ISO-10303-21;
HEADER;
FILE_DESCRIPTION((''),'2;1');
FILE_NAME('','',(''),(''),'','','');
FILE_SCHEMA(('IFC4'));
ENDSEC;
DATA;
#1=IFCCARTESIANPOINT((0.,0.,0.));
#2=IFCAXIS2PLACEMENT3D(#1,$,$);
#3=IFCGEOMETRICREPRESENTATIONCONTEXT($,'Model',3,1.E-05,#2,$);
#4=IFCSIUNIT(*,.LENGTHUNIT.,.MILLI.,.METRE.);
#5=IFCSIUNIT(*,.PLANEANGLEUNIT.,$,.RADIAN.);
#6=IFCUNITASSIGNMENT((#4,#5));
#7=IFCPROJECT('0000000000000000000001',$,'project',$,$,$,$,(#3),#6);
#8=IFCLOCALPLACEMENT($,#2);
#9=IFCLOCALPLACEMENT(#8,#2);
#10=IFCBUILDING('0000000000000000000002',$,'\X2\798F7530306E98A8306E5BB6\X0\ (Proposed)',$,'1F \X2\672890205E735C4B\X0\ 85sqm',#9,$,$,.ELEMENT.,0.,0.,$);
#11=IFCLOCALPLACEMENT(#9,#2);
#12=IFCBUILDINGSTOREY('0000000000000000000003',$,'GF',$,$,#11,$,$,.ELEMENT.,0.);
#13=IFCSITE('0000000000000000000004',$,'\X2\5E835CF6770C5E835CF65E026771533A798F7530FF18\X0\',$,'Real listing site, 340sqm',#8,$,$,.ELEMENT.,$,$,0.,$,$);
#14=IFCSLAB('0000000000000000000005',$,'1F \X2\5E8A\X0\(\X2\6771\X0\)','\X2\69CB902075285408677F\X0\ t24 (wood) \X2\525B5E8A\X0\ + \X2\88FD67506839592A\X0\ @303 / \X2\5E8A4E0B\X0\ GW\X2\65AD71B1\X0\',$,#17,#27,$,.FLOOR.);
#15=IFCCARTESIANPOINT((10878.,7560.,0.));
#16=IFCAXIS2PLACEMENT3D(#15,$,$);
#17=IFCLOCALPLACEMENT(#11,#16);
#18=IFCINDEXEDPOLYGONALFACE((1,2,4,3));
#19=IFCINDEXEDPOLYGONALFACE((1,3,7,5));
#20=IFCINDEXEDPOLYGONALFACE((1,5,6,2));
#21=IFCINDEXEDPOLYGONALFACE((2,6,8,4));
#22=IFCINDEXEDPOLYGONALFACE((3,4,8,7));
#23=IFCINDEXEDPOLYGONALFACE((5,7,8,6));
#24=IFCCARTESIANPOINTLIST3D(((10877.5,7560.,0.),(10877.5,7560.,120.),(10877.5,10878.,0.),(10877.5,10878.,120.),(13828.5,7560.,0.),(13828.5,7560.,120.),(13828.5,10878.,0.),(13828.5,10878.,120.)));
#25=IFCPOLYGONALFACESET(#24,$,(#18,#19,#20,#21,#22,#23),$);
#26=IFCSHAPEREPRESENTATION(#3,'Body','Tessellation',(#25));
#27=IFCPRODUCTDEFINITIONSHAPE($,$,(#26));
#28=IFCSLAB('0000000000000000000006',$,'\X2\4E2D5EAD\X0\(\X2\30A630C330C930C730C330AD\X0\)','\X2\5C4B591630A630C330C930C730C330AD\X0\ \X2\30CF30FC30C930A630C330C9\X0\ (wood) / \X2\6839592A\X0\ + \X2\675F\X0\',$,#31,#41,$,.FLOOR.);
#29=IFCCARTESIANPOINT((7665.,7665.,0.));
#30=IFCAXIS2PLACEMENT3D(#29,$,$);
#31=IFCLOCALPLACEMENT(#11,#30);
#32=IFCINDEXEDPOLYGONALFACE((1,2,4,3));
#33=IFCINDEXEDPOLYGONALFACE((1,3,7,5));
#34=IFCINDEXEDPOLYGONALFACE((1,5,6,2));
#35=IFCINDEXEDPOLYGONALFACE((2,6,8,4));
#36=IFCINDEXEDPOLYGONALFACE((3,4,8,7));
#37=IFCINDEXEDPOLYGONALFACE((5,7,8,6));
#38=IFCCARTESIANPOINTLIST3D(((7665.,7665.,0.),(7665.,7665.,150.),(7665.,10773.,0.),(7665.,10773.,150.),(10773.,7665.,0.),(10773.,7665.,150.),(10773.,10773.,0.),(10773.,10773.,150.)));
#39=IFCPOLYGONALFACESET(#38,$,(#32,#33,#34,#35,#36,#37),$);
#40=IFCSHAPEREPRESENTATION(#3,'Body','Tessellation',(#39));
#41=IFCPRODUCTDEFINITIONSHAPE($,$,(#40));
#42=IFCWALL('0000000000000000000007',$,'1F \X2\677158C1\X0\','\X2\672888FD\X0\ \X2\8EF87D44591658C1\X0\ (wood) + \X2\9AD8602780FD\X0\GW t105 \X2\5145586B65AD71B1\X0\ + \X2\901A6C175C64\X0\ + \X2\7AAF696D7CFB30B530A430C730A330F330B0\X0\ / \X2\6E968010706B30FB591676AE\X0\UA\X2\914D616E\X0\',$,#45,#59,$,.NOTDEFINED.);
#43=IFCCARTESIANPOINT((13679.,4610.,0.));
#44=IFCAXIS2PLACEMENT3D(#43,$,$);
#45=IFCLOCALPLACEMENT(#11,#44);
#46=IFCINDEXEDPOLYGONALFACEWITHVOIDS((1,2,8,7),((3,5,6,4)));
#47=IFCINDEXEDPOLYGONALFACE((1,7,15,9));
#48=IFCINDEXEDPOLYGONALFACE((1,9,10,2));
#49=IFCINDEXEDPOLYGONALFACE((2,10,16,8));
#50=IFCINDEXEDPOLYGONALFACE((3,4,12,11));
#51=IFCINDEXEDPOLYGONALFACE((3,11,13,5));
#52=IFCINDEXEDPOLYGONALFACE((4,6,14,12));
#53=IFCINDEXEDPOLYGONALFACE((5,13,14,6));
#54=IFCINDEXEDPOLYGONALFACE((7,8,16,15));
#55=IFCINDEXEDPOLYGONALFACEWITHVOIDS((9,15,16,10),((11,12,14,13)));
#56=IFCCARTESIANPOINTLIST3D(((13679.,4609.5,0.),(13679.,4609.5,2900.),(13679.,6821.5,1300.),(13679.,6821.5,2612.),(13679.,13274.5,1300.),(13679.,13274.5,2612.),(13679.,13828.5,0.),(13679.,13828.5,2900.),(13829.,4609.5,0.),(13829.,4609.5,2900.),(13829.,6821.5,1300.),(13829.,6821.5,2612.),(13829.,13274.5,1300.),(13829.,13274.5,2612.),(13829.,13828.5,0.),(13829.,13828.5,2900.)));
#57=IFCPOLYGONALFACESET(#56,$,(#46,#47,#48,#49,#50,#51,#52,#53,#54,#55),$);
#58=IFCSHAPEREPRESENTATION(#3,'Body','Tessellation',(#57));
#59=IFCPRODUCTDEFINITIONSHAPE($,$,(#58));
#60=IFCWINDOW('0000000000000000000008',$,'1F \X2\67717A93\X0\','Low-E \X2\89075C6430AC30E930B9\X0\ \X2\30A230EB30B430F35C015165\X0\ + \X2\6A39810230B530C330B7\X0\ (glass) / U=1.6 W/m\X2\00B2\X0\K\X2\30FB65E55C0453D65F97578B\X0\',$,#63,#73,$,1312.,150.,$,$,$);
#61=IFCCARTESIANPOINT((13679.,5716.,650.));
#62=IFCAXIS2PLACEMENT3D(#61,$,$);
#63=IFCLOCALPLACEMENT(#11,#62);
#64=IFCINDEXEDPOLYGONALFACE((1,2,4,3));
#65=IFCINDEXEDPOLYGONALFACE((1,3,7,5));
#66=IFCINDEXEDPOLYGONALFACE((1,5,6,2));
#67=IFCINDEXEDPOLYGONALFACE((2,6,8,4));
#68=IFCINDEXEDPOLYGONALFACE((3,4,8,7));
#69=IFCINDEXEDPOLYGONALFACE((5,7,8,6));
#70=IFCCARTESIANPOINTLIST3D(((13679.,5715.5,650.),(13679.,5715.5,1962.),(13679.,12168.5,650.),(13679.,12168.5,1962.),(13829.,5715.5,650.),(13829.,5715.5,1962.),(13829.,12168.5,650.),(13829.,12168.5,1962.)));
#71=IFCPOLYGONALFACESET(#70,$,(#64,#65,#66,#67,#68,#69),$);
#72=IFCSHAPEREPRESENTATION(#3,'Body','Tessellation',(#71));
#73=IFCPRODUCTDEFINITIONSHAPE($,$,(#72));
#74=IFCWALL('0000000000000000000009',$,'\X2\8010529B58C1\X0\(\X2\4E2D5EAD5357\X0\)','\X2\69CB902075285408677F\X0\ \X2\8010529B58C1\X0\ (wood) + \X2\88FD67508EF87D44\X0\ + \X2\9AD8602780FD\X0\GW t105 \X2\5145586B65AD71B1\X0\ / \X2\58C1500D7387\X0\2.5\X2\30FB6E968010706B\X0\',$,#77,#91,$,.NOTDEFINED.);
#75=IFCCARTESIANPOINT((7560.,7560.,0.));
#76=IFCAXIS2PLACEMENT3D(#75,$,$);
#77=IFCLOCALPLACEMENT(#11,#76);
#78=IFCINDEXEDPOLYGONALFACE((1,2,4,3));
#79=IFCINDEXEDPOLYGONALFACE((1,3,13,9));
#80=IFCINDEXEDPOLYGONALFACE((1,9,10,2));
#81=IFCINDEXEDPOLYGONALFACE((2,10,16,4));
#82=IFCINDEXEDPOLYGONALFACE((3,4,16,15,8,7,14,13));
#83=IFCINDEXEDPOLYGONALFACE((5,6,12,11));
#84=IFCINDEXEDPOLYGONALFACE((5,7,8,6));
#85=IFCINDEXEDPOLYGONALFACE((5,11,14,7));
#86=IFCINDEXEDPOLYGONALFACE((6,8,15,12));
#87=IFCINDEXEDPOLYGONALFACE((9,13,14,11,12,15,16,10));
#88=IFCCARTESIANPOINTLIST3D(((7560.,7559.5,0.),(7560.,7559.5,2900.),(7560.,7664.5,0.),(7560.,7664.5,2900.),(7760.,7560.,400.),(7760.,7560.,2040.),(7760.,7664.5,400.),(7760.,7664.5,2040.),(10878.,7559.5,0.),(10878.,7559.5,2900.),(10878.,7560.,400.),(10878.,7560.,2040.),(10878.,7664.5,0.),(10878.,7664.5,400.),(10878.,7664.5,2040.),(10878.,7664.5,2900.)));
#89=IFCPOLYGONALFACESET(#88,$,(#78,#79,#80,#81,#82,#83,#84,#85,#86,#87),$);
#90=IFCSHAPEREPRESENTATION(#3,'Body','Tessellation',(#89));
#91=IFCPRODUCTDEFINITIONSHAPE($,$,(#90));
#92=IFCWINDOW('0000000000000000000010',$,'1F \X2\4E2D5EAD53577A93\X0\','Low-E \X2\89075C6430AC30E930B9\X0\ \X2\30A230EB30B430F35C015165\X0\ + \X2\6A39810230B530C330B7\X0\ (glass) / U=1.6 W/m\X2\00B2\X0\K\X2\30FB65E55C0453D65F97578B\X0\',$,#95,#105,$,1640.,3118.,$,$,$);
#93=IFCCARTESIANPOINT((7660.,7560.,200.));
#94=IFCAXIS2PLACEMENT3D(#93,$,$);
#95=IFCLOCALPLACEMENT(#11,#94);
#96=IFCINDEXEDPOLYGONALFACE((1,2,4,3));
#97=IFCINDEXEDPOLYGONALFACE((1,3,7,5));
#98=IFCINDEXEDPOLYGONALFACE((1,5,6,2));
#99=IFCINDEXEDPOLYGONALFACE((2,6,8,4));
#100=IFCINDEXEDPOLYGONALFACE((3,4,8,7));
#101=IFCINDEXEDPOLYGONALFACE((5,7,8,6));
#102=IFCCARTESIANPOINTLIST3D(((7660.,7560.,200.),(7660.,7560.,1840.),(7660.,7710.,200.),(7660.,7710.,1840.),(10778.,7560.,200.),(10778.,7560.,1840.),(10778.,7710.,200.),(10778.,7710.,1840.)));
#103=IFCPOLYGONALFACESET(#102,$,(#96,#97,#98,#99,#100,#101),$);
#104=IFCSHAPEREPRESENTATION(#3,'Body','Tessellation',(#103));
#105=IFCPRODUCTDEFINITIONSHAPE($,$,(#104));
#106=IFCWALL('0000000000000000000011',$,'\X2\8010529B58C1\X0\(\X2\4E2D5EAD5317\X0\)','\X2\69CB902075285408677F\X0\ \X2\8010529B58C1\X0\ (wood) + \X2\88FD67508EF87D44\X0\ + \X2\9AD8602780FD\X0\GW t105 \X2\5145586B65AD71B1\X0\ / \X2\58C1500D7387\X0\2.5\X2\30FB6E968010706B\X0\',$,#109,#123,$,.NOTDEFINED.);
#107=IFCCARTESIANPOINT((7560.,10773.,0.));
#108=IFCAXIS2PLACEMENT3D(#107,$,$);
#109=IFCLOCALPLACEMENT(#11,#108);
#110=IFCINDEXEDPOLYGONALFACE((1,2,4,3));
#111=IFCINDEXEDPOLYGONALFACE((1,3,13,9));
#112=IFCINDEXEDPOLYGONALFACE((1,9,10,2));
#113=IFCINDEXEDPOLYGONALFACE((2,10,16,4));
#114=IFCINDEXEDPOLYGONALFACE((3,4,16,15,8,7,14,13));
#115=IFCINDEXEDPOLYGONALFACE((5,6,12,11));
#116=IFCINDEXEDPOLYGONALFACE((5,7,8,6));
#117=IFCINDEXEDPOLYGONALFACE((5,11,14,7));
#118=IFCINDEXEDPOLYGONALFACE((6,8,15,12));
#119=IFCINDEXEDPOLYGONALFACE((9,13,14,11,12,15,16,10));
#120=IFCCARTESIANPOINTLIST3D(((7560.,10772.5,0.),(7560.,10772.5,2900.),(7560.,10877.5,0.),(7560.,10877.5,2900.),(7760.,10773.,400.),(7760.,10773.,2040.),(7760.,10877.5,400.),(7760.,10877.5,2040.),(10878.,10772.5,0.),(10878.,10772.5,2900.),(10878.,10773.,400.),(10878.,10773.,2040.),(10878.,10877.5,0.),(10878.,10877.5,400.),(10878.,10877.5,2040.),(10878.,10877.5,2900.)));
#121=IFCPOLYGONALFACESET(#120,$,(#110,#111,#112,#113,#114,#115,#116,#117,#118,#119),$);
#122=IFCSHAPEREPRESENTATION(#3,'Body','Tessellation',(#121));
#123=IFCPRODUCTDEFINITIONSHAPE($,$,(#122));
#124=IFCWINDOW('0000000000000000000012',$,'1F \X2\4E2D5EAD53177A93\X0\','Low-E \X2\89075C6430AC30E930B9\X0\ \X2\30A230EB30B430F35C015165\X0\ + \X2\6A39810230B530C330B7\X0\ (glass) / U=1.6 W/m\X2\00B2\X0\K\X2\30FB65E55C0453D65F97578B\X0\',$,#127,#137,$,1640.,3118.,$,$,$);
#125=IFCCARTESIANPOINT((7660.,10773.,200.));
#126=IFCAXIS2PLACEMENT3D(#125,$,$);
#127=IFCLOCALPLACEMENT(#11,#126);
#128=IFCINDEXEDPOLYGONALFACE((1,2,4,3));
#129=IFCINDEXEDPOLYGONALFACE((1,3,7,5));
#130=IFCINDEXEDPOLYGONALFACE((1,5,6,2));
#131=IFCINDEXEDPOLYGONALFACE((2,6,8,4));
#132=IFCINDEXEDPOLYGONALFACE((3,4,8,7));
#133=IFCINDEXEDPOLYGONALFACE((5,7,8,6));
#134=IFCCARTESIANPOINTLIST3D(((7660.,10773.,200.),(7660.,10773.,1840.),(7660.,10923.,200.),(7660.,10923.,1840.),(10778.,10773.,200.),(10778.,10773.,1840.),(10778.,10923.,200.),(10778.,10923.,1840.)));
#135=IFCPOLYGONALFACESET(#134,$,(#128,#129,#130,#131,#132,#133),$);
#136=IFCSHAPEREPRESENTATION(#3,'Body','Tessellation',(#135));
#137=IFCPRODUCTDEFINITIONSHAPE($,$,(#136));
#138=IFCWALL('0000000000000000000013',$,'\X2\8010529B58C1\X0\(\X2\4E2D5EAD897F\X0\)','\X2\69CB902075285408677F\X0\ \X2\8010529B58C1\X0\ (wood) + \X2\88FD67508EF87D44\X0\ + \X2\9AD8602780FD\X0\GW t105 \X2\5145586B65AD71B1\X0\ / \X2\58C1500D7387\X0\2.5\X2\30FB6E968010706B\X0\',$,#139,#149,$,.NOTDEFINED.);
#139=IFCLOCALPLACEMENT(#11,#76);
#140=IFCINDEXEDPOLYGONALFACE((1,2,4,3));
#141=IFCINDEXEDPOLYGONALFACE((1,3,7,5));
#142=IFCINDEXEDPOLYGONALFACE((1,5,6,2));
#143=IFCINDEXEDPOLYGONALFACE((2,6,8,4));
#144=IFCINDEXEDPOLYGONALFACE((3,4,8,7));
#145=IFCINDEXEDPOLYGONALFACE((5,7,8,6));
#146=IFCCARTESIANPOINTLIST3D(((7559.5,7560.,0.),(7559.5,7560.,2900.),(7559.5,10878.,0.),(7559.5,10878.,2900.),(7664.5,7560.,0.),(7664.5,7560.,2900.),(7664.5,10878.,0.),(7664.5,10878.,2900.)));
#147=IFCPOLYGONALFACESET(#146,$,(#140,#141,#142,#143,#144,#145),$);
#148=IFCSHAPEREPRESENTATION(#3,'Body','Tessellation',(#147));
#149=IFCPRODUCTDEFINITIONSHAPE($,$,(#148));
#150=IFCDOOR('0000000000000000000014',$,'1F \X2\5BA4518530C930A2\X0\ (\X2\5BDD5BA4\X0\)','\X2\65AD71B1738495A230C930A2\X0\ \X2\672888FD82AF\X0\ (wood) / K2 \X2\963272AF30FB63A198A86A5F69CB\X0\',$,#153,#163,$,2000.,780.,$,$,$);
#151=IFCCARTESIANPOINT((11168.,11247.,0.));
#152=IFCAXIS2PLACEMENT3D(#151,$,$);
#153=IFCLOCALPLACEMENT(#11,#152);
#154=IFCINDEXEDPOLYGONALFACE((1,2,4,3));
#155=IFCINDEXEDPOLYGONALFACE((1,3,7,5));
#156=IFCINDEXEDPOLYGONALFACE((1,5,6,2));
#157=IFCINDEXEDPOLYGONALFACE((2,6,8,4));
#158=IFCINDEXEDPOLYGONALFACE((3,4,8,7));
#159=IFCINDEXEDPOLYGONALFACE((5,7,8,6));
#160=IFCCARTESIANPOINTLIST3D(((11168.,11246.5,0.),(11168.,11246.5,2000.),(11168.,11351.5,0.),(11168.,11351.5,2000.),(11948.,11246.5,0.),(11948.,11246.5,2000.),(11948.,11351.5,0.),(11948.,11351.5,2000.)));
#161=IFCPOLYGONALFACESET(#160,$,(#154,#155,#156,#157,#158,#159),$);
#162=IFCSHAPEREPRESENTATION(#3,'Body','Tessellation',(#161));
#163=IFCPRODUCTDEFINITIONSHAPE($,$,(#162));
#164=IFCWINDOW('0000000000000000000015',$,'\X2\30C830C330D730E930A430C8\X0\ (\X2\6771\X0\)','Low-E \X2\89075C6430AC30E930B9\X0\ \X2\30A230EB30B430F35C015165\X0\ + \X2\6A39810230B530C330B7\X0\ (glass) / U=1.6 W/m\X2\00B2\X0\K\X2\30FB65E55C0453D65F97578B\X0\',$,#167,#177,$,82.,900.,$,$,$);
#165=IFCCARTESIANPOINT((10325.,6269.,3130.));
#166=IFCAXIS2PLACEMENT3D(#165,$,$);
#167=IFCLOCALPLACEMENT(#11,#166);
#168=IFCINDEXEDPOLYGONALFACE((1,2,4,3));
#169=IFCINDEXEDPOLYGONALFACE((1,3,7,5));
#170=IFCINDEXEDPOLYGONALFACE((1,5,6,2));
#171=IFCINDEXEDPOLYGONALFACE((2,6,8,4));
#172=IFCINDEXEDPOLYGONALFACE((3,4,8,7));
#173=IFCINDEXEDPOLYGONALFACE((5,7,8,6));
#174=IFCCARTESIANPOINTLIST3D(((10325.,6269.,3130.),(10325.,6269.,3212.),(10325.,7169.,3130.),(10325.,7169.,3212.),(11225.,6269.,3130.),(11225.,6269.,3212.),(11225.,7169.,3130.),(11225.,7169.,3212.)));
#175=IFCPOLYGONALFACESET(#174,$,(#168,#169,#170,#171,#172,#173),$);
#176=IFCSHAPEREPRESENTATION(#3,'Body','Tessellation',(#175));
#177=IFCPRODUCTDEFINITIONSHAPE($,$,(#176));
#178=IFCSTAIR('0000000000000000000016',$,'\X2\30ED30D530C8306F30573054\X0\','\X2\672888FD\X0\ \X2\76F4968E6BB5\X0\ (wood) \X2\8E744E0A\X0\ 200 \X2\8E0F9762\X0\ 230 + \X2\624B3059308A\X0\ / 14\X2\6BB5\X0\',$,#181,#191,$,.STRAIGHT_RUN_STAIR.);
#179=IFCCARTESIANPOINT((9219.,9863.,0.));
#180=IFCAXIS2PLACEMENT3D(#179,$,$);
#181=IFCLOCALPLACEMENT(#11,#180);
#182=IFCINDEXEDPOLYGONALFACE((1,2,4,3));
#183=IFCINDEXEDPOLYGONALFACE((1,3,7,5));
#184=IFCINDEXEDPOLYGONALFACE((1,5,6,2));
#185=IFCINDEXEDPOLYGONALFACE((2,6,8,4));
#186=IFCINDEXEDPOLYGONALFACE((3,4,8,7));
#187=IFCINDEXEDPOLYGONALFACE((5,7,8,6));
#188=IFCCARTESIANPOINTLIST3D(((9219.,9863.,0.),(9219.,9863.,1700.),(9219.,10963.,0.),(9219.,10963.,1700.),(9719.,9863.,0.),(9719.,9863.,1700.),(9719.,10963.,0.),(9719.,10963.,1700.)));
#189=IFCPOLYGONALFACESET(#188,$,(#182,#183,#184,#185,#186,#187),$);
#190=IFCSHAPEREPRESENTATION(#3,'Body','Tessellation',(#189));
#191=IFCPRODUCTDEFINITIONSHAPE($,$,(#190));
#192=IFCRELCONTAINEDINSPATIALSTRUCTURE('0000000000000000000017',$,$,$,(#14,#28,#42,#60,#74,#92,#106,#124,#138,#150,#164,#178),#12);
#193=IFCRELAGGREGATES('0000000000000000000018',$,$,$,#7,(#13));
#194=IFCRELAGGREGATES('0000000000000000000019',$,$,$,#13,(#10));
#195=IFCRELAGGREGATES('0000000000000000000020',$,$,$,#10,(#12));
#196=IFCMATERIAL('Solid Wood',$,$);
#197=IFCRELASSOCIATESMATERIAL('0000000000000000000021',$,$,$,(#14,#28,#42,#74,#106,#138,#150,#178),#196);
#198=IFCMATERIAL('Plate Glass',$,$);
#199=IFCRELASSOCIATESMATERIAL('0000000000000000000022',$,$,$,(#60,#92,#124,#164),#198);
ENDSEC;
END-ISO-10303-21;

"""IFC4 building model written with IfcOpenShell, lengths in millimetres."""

from ifc_helpers import new_model, si_unit, frame, frame_2d, origin, place, context, project, spatial, rectangle, extrude, material, element, fill, save


model = new_model("IFC4")

# Units and contexts
model_context = context("Model", 3, precision=1e-05, world=origin())
ifc_project = project(units=[si_unit("LENGTHUNIT", "METRE", prefix="MILLI"), si_unit("PLANEANGLEUNIT", "RADIAN")], contexts=[model_context])

# Site, building, storey
site_placement = place(None, origin())
site = spatial("IfcSite", under=ifc_project, at=site_placement, Name="広島県広島市東区福田８", ObjectType="Real listing site, 340sqm", CompositionType="ELEMENT", RefElevation=0.0)
building_placement = place(site_placement, origin())
building = spatial("IfcBuilding", under=site, at=building_placement, Name="福田の風の家 (Proposed)", ObjectType="1F 木造平屋 85sqm", CompositionType="ELEMENT", ElevationOfRefHeight=0.0, ElevationOfTerrain=0.0)
storey_placement = place(building_placement, origin())
storey = spatial("IfcBuildingStorey", under=building, at=storey_placement, Name="GF", CompositionType="ELEMENT", Elevation=0.0)

# Slabs
ifc_material_1 = material(Name="Solid Wood")
slab_1_placement = place(storey_placement, frame((10878.0, 7560.0, 0.0)))
element("IfcSlab", 1, at=slab_1_placement, inside=storey, material=ifc_material_1, Name="1F 床(東)", Description="構造用合板 t24 (wood) 剛床 + 製材根太 @303 / 床下 GW断熱", PredefinedType="FLOOR", context=model_context, shape_type="SweptSolid", body=[
    extrude(rectangle(XDim=2951.0, YDim=3318.0, at=frame_2d((1475.0, 1659.0))), frame((10878.0, 7560.0, 0.0)), (0.0, 0.0, 1.0), 120.0),
])
slab_2_placement = place(storey_placement, frame((7665.0, 7665.0, 0.0)))
element("IfcSlab", 2, at=slab_2_placement, inside=storey, material=ifc_material_1, Name="中庭(ウッドデッキ)", Description="屋外ウッドデッキ ハードウッド (wood) / 根太 + 束", PredefinedType="FLOOR", context=model_context, shape_type="SweptSolid", body=[
    extrude(rectangle(XDim=3108.0, YDim=3108.0, at=frame_2d((1554.0, 1554.0))), frame((7665.0, 7665.0, 0.0)), (0.0, 0.0, 1.0), 150.0),
])

# Walls, openings, windows
wall_1_placement = place(storey_placement, frame((13679.0, 4610.0, 0.0)))
wall_1 = element("IfcWall", 3, at=wall_1_placement, inside=storey, material=ifc_material_1, Name="1F 東壁", Description="木製 軸組外壁 (wood) + 高性能GW t105 充填断熱 + 通気層 + 窯業系サイディング / 準耐火・外皮UA配慮", PredefinedType="NOTDEFINED", context=model_context, shape_type="SweptSolid", body=[
    extrude(rectangle(XDim=150.0, YDim=9219.0, at=frame_2d((75.0, 4609.0))), frame((13679.0, 4610.0, 0.0)), (0.0, 0.0, 1.0), 2900.0),
])
opening_1_placement = place(storey_placement, frame((13679.0, 5716.0, 650.0)))
opening_1 = element("IfcOpeningElement", 4, at=opening_1_placement, cuts=wall_1, PredefinedType="NOTDEFINED", context=model_context, shape_type="SweptSolid", body=[
    extrude(rectangle(XDim=150.0, YDim=6453.0, at=frame_2d((75.0, 3226.0))), frame((13679.0, 5716.0, 650.0)), (0.0, 0.0, 1.0), 1312.0),
])
ifc_material_2 = material(Name="Plate Glass")
window_1_placement = place(storey_placement, frame((13679.0, 5716.0, 650.0)))
window_1 = element("IfcWindow", 5, at=window_1_placement, inside=storey, material=ifc_material_2, Name="1F 東窓", Description="Low-E 複層ガラス アルゴン封入 + 樹脂サッシ (glass) / U=1.6 W/m²K・日射取得型", OverallHeight=1312.0, OverallWidth=150.0, context=model_context, shape_type="SweptSolid", body=[
    extrude(rectangle(XDim=150.0, YDim=6453.0, at=frame_2d((75.0, 3226.0))), frame((13679.0, 5716.0, 650.0)), (0.0, 0.0, 1.0), 1312.0),
])
fill(opening_1, window_1)
wall_2_placement = place(storey_placement, frame((7560.0, 7560.0, 0.0)))
wall_2 = element("IfcWall", 6, at=wall_2_placement, inside=storey, material=ifc_material_1, Name="耐力壁(中庭南)", Description="構造用合板 耐力壁 (wood) + 製材軸組 + 高性能GW t105 充填断熱 / 壁倍率2.5・準耐火", PredefinedType="NOTDEFINED", context=model_context, shape_type="SweptSolid", body=[
    extrude(rectangle(XDim=3318.0, YDim=105.0, at=frame_2d((1659.0, 52.0))), frame((7560.0, 7560.0, 0.0)), (0.0, 0.0, 1.0), 2900.0),
])
opening_2_placement = place(storey_placement, frame((7660.0, 7560.0, 200.0)))
opening_2 = element("IfcOpeningElement", 7, at=opening_2_placement, cuts=wall_2, PredefinedType="NOTDEFINED", context=model_context, shape_type="SweptSolid", body=[
    extrude(rectangle(XDim=3118.0, YDim=150.0, at=frame_2d((1559.0, 75.0))), frame((7660.0, 7560.0, 200.0)), (0.0, 0.0, 1.0), 1640.0),
])
window_2_placement = place(storey_placement, frame((7660.0, 7560.0, 200.0)))
window_2 = element("IfcWindow", 8, at=window_2_placement, inside=storey, material=ifc_material_2, Name="1F 中庭南窓", Description="Low-E 複層ガラス アルゴン封入 + 樹脂サッシ (glass) / U=1.6 W/m²K・日射取得型", OverallHeight=1640.0, OverallWidth=3118.0, context=model_context, shape_type="SweptSolid", body=[
    extrude(rectangle(XDim=3118.0, YDim=150.0, at=frame_2d((1559.0, 75.0))), frame((7660.0, 7560.0, 200.0)), (0.0, 0.0, 1.0), 1640.0),
])
fill(opening_2, window_2)
wall_3_placement = place(storey_placement, frame((7560.0, 10773.0, 0.0)))
wall_3 = element("IfcWall", 9, at=wall_3_placement, inside=storey, material=ifc_material_1, Name="耐力壁(中庭北)", Description="構造用合板 耐力壁 (wood) + 製材軸組 + 高性能GW t105 充填断熱 / 壁倍率2.5・準耐火", PredefinedType="NOTDEFINED", context=model_context, shape_type="SweptSolid", body=[
    extrude(rectangle(XDim=3318.0, YDim=105.0, at=frame_2d((1659.0, 52.0))), frame((7560.0, 10773.0, 0.0)), (0.0, 0.0, 1.0), 2900.0),
])
opening_3_placement = place(storey_placement, frame((7660.0, 10773.0, 200.0)))
opening_3 = element("IfcOpeningElement", 10, at=opening_3_placement, cuts=wall_3, PredefinedType="NOTDEFINED", context=model_context, shape_type="SweptSolid", body=[
    extrude(rectangle(XDim=3118.0, YDim=150.0, at=frame_2d((1559.0, 75.0))), frame((7660.0, 10773.0, 200.0)), (0.0, 0.0, 1.0), 1640.0),
])
window_3_placement = place(storey_placement, frame((7660.0, 10773.0, 200.0)))
window_3 = element("IfcWindow", 11, at=window_3_placement, inside=storey, material=ifc_material_2, Name="1F 中庭北窓", Description="Low-E 複層ガラス アルゴン封入 + 樹脂サッシ (glass) / U=1.6 W/m²K・日射取得型", OverallHeight=1640.0, OverallWidth=3118.0, context=model_context, shape_type="SweptSolid", body=[
    extrude(rectangle(XDim=3118.0, YDim=150.0, at=frame_2d((1559.0, 75.0))), frame((7660.0, 10773.0, 200.0)), (0.0, 0.0, 1.0), 1640.0),
])
fill(opening_3, window_3)

# Wall
wall_4_placement = place(storey_placement, frame((7560.0, 7560.0, 0.0)))
element("IfcWall", 12, at=wall_4_placement, inside=storey, material=ifc_material_1, Name="耐力壁(中庭西)", Description="構造用合板 耐力壁 (wood) + 製材軸組 + 高性能GW t105 充填断熱 / 壁倍率2.5・準耐火", PredefinedType="NOTDEFINED", context=model_context, shape_type="SweptSolid", body=[
    extrude(rectangle(XDim=105.0, YDim=3318.0, at=frame_2d((52.0, 1659.0))), frame((7560.0, 7560.0, 0.0)), (0.0, 0.0, 1.0), 2900.0),
])

# Door
door_placement = place(storey_placement, frame((11168.0, 11247.0, 0.0)))
element("IfcDoor", 13, at=door_placement, inside=storey, material=ifc_material_1, Name="1F 室内ドア (寝室)", Description="断熱玄関ドア 木製芯 (wood) / K2 防犯・採風機構", OverallHeight=2000.0, OverallWidth=780.0, context=model_context, shape_type="SweptSolid", body=[
    extrude(rectangle(XDim=780.0, YDim=105.0, at=frame_2d((390.0, 52.0))), frame((11168.0, 11247.0, 0.0)), (0.0, 0.0, 1.0), 2000.0),
])

# Window
window_4_placement = place(storey_placement, frame((10325.0, 6269.0, 3130.0)))
element("IfcWindow", 14, at=window_4_placement, inside=storey, material=ifc_material_2, Name="トップライト (東)", Description="Low-E 複層ガラス アルゴン封入 + 樹脂サッシ (glass) / U=1.6 W/m²K・日射取得型", OverallHeight=82.0, OverallWidth=900.0, context=model_context, shape_type="SweptSolid", body=[
    extrude(rectangle(XDim=900.0, YDim=900.0, at=frame_2d((450.0, 450.0))), frame((10325.0, 6269.0, 3130.0)), (0.0, 0.0, 1.0), 82.0),
])

# Stair
stair_placement = place(storey_placement, frame((9219.0, 9863.0, 0.0)))
element("IfcStair", 15, at=stair_placement, inside=storey, material=ifc_material_1, Name="ロフトはしご", Description="木製 直階段 (wood) 蹴上 200 踏面 230 + 手すり / 14段", PredefinedType="STRAIGHT_RUN_STAIR", context=model_context, shape_type="SweptSolid", body=[
    extrude(rectangle(XDim=500.0, YDim=1100.0, at=frame_2d((250.0, 550.0))), frame((9219.0, 9863.0, 0.0)), (0.0, 0.0, 1.0), 1700.0),
])

save(model, "model.ifc")
